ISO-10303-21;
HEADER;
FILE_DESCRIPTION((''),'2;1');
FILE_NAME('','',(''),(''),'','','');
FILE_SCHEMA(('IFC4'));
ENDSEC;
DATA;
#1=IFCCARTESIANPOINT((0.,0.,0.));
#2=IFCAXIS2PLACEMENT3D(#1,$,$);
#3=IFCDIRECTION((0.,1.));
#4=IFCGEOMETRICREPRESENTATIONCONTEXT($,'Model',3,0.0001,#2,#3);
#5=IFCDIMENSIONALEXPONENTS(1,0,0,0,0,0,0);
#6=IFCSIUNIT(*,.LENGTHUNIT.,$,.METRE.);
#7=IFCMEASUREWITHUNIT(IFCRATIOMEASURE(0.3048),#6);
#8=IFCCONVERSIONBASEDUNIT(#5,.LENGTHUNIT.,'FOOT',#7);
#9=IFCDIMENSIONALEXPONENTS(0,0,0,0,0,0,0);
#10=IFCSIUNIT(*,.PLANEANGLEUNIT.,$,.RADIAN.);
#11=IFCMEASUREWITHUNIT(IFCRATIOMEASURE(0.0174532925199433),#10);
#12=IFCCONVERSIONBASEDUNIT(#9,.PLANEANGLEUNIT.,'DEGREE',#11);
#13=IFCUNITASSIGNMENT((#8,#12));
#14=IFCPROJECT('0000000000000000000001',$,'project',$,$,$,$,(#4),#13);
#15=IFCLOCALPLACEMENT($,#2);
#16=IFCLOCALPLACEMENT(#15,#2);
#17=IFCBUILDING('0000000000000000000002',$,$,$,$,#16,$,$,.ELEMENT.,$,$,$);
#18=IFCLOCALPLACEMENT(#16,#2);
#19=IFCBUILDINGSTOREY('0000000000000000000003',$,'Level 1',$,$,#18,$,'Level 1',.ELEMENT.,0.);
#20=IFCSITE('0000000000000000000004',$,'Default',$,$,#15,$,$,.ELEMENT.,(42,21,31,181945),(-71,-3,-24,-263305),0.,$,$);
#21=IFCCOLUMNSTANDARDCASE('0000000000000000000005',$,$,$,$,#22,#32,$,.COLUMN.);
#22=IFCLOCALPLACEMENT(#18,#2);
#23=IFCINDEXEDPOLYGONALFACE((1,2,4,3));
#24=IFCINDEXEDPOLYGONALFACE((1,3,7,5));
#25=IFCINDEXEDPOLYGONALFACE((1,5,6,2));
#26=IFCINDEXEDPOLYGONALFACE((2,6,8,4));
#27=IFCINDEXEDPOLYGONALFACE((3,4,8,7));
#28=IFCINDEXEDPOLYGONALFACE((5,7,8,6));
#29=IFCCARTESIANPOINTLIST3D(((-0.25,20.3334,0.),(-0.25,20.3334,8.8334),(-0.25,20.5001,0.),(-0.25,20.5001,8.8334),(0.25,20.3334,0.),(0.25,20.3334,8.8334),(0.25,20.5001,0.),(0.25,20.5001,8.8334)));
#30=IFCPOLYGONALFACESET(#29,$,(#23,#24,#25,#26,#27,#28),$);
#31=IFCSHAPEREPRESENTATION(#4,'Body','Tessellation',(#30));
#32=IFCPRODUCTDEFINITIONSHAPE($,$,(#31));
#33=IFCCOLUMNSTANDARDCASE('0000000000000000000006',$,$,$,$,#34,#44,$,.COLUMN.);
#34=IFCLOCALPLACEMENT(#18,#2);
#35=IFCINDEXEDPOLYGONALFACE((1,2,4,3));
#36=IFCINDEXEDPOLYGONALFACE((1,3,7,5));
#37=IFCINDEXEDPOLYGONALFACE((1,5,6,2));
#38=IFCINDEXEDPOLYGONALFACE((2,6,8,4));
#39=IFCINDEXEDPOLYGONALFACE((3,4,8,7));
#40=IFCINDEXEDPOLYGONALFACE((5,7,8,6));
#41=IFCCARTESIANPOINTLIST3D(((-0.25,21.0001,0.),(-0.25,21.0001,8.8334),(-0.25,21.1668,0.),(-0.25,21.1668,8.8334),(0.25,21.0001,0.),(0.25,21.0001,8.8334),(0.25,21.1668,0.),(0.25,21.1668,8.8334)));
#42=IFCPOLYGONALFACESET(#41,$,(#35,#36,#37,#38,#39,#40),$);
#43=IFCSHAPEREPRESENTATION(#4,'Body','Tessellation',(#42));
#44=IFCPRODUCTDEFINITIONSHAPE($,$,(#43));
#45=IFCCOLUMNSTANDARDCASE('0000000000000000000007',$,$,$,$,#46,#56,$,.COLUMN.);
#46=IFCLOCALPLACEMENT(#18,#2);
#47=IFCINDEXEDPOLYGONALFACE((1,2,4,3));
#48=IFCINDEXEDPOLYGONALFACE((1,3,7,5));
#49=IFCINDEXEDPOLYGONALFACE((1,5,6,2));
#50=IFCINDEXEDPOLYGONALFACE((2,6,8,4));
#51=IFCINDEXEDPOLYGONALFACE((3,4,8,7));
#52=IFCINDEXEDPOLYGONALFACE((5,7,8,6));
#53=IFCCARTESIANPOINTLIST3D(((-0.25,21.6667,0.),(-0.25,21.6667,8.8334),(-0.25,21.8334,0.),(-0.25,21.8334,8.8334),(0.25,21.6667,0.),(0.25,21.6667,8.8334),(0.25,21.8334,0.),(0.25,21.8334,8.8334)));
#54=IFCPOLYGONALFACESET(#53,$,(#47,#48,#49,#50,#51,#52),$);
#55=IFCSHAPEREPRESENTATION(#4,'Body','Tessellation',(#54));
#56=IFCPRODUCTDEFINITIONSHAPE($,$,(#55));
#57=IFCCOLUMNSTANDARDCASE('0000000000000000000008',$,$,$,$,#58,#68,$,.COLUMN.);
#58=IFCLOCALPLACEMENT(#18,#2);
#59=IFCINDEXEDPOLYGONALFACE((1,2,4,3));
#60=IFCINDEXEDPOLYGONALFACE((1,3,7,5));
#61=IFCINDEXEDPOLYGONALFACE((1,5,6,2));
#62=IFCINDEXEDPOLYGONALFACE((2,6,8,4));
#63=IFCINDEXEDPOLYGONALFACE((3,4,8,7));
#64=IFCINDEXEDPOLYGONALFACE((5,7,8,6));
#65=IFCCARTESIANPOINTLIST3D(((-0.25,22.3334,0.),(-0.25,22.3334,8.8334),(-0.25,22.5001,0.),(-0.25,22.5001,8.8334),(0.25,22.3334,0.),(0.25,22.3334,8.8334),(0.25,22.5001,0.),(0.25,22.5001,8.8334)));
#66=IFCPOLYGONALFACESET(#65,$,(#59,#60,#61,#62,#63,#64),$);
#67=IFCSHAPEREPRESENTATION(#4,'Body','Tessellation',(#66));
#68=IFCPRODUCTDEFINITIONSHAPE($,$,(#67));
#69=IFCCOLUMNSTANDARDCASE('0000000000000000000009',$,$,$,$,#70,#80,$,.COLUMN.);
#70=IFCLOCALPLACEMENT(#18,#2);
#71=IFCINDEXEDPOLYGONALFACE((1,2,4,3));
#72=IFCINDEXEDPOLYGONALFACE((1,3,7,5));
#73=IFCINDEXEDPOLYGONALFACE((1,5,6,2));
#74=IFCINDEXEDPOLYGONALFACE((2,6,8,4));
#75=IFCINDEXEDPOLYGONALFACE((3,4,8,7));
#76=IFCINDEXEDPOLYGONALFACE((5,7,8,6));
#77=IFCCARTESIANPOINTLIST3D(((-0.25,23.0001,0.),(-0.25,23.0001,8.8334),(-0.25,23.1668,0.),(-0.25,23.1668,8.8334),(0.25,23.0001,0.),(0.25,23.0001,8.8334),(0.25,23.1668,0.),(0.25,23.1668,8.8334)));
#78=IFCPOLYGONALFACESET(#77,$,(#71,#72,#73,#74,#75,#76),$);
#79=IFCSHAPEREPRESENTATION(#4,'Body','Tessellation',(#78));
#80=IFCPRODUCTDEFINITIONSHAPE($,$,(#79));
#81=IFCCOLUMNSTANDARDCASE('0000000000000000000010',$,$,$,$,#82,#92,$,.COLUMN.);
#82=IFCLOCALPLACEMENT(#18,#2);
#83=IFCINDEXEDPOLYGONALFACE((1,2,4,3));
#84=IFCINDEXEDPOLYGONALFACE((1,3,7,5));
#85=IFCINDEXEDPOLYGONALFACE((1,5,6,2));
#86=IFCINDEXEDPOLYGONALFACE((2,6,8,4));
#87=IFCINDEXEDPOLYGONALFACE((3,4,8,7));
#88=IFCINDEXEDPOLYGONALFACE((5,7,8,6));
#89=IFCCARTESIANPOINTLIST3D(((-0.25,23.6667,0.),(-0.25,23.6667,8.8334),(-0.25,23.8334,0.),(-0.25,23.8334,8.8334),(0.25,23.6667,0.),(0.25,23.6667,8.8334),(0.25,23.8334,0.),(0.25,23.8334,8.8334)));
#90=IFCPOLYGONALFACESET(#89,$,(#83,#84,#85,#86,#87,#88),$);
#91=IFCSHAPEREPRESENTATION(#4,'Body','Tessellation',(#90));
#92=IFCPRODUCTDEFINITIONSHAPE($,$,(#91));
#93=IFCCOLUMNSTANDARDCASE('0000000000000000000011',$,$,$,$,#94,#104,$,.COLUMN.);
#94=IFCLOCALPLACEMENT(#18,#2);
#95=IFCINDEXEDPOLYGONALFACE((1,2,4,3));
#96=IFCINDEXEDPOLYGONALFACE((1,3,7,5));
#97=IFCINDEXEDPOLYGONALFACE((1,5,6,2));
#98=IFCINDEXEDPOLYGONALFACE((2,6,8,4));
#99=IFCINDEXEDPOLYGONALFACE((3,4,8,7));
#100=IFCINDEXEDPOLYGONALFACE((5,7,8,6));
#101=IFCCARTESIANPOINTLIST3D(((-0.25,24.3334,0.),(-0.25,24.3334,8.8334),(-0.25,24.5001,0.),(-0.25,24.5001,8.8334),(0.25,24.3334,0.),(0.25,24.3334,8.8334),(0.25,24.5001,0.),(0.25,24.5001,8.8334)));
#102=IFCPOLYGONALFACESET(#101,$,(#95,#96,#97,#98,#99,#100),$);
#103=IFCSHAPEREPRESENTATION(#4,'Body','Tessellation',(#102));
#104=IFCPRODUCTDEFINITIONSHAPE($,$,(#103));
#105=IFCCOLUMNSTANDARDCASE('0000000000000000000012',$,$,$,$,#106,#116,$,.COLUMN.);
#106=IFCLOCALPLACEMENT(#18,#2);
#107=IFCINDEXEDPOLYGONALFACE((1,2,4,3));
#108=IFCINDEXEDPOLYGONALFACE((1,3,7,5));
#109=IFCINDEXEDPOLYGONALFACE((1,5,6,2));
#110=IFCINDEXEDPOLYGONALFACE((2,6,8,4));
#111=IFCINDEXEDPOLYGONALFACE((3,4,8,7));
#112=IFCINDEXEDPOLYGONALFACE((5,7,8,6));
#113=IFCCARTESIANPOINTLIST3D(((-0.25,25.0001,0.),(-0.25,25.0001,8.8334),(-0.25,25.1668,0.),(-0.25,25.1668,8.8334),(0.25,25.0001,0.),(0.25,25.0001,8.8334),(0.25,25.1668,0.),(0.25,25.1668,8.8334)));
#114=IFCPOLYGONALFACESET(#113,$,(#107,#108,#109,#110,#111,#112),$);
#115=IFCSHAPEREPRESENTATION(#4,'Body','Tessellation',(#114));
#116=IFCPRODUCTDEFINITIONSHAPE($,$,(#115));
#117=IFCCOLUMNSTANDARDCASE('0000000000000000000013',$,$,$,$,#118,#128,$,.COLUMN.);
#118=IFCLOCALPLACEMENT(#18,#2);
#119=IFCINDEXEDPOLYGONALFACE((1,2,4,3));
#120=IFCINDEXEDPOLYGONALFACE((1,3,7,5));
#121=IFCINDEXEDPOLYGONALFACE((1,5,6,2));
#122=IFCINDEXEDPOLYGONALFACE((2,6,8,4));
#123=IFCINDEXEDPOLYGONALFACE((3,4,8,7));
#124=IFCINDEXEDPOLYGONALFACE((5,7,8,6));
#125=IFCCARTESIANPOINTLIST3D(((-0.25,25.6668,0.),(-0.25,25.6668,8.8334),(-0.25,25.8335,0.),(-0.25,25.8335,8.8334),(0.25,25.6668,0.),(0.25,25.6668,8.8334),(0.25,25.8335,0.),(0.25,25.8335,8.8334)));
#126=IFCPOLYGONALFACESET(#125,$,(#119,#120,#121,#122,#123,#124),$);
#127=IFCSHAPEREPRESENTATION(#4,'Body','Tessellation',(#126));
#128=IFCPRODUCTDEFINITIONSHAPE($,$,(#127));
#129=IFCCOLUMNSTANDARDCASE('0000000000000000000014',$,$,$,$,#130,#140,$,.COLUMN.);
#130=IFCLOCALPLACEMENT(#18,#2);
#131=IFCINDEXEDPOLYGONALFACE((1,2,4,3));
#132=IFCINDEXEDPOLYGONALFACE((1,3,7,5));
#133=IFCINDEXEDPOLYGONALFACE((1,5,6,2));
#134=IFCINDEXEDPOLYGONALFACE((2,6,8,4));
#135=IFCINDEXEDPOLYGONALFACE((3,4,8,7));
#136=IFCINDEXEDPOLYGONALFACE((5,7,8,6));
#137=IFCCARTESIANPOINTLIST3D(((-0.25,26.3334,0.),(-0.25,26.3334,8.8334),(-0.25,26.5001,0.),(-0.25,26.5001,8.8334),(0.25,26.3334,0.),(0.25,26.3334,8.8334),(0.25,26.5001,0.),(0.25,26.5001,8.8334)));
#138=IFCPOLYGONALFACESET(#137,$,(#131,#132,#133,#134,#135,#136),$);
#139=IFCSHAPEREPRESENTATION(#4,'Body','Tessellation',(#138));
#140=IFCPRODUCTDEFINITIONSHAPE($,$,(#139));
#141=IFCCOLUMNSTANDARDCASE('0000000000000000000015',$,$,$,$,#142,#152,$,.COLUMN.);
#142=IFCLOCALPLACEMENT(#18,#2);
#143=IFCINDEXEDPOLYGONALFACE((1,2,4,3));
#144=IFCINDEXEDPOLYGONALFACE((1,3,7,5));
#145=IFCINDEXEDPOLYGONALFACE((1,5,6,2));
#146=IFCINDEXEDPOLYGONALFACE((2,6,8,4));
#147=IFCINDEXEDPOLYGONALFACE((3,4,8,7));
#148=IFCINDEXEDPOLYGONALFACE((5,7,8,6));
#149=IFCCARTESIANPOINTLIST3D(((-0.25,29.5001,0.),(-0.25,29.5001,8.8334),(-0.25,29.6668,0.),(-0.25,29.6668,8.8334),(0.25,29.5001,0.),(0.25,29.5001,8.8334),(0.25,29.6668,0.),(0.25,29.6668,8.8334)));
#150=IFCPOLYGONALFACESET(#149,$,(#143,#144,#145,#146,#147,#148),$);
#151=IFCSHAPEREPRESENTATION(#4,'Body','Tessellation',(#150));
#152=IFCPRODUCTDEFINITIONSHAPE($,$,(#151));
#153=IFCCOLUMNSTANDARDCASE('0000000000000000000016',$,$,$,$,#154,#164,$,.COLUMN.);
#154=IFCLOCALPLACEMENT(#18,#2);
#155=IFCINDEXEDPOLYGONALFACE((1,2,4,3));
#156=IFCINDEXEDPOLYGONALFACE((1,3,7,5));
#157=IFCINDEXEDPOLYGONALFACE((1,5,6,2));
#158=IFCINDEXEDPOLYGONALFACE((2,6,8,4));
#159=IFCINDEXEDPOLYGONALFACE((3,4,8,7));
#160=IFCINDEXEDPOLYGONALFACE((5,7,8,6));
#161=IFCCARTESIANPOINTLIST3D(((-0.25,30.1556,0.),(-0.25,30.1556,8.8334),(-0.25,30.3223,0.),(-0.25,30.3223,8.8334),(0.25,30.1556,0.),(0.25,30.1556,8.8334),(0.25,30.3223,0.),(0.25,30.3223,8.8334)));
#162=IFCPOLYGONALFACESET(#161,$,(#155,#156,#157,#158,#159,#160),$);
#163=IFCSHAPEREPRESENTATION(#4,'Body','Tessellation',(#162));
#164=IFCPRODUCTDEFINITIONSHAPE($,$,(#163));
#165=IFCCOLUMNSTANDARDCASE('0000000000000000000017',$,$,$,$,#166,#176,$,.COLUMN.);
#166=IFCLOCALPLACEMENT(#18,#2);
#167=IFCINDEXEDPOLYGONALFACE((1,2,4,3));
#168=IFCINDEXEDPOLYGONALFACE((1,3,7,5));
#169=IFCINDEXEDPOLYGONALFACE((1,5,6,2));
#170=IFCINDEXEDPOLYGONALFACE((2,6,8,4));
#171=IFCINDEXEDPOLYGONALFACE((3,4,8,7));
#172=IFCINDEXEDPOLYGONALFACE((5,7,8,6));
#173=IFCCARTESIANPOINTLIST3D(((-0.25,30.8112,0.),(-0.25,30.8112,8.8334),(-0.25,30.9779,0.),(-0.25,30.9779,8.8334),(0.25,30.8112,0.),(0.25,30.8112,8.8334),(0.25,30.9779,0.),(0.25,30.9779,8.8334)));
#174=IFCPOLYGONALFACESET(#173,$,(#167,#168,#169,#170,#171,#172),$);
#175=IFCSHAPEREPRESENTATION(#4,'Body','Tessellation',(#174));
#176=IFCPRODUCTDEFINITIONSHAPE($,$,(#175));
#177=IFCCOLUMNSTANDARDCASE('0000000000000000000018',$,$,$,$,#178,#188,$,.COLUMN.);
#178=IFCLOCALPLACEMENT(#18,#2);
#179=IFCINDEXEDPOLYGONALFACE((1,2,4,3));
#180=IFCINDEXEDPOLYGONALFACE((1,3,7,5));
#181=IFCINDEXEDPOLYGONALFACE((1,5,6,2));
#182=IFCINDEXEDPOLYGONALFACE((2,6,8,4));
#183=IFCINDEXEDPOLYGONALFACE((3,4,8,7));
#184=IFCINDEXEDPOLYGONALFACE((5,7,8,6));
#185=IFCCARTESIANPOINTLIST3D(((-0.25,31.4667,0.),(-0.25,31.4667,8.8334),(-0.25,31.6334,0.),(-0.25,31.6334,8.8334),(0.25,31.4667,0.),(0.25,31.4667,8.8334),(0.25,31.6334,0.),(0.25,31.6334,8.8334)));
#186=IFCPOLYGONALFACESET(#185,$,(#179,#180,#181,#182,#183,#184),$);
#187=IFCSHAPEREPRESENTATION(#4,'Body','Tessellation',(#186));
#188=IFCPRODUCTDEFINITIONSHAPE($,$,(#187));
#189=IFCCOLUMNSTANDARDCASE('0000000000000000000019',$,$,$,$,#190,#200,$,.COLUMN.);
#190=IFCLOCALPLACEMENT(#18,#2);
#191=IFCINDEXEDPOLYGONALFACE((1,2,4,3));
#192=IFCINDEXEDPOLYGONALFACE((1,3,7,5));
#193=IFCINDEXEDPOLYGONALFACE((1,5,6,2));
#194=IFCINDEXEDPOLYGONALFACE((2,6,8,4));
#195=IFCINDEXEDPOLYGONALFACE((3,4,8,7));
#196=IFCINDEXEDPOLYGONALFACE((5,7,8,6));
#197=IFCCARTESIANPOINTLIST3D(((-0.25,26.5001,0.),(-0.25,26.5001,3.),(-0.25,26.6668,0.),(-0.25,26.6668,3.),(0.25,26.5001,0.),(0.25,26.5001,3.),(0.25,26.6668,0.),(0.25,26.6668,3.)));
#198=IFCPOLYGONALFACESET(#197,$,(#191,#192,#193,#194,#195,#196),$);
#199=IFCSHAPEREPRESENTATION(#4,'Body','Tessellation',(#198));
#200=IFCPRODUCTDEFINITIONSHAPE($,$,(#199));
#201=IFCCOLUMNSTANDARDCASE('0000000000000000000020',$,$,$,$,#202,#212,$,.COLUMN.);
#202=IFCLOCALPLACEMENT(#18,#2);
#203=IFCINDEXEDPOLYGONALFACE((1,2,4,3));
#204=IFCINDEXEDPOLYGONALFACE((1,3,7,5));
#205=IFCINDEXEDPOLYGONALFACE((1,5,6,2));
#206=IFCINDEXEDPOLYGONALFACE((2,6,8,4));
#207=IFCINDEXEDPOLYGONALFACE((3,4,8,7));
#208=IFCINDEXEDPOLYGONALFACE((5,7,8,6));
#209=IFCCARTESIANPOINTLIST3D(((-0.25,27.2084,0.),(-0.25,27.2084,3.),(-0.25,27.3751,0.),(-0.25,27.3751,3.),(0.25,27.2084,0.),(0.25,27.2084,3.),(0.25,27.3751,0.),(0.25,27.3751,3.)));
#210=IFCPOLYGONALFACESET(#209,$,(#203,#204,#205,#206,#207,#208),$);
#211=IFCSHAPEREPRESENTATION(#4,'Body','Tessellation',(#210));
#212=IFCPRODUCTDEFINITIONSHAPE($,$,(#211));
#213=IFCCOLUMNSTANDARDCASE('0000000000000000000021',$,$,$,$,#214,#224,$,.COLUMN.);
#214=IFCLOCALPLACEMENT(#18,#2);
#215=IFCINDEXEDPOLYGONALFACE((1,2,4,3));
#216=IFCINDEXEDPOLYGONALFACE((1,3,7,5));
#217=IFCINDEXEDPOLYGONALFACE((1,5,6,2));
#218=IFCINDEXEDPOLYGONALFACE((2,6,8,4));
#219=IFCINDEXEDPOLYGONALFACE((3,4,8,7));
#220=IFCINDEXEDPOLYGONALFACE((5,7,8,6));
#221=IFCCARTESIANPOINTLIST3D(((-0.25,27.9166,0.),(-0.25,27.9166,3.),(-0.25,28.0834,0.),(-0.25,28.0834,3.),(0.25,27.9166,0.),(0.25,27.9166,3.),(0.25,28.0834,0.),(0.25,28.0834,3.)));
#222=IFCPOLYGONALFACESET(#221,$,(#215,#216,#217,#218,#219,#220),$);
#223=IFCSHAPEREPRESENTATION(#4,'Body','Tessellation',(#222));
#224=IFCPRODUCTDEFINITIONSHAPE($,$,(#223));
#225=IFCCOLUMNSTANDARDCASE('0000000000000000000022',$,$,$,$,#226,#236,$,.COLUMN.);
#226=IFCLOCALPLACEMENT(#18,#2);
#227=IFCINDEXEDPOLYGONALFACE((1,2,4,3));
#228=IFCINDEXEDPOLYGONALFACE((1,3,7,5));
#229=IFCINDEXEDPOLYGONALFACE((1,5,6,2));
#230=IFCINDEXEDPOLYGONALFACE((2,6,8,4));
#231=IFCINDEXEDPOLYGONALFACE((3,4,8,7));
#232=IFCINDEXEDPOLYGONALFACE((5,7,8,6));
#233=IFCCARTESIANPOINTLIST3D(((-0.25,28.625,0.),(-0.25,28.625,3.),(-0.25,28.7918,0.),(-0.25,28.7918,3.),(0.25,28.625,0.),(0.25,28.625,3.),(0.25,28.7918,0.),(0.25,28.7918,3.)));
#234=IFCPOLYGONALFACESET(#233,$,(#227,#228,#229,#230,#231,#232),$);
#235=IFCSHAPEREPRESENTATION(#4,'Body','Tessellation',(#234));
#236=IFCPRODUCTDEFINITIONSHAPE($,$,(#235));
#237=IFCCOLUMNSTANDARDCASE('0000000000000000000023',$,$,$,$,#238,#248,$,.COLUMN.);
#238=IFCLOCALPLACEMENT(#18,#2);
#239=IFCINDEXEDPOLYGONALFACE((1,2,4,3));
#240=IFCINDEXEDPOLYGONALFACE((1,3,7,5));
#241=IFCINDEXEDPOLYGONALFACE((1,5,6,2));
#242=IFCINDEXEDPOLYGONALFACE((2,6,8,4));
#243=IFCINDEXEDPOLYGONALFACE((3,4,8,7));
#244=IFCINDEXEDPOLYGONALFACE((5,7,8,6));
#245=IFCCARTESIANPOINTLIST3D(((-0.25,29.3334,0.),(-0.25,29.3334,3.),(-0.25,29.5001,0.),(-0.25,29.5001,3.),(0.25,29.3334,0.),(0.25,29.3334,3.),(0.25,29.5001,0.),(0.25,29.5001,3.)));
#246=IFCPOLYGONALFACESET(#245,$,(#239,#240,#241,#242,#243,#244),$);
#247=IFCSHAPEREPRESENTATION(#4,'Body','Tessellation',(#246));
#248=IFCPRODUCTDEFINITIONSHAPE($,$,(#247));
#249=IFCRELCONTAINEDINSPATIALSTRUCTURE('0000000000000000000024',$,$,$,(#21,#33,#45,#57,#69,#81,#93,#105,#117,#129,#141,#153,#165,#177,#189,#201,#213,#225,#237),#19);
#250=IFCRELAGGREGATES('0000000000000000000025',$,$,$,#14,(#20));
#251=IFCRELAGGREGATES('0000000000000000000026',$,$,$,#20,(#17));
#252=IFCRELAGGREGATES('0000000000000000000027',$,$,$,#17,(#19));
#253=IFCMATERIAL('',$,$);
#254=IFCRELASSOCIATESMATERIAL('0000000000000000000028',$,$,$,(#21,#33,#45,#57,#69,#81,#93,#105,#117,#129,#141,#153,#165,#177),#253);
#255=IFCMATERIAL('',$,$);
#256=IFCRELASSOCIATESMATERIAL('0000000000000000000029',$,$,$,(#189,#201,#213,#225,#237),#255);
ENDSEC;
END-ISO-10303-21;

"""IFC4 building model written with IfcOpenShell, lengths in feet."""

from ifc_helpers import new_model, entity, si_unit, converted_unit, direction, frame, origin, place, context, project, spatial, rectangle, extrude, material, element, save


model = new_model("IFC4")

# Units and contexts
model_context = context("Model", 3, precision=0.0001, world=origin(), true_north=direction((0.0, 1.0)))
ifc_project = project(units=[converted_unit("LENGTHUNIT", "FOOT", entity("IfcRatioMeasure", 0.3048), si_unit("LENGTHUNIT", "METRE"), dimensions=[1, 0, 0, 0, 0, 0, 0]), converted_unit("PLANEANGLEUNIT", "DEGREE", entity("IfcRatioMeasure", 0.0174532925199433), si_unit("PLANEANGLEUNIT", "RADIAN"), dimensions=[0, 0, 0, 0, 0, 0, 0])], contexts=[model_context])

# Site, building, storey
site_placement = place(None, origin())
site = spatial("IfcSite", under=ifc_project, at=site_placement, Name="Default", CompositionType="ELEMENT", RefLatitude=(42, 21, 31, 181945), RefLongitude=(-71, -3, -24, -263305), RefElevation=0.0)
building_placement = place(site_placement, origin())
building = spatial("IfcBuilding", under=site, at=building_placement, CompositionType="ELEMENT")
storey_placement = place(building_placement, origin())
storey = spatial("IfcBuildingStorey", under=building, at=storey_placement, Name="Level 1", LongName="Level 1", CompositionType="ELEMENT", Elevation=0.0)

# Columns
ifc_material_1 = material(Name="")
placement_1 = place(storey_placement, frame((0.0, -0.25, 0.0), z_axis=(0.0, 0.0, 1.0), x_axis=(0.0, 1.0, 0.0)))
for number, where, z_axis, x_axis in (
    (1, (20.6667, 0.0, 0.0), (0.0, 0.0, 1.0), (1.0, 0.0, 0.0)),
    (2, (21.3334, 0.0, 0.0), (0.0, 0.0, 1.0), (1.0, 0.0, 0.0)),
    (3, (22.0, 0.0, 0.0), (0.0, 0.0, 1.0), (1.0, 0.0, 0.0)),
    (4, (22.6667, 0.0, 0.0), (0.0, 0.0, 1.0), (1.0, 0.0, 0.0)),
    (5, (23.3334, 0.0, 0.0), (0.0, 0.0, 1.0), (1.0, 0.0, 0.0)),
    (6, (24.0, 0.0, 0.0), (0.0, 0.0, 1.0), (1.0, 0.0, 0.0)),
    (7, (24.6667, 0.0, 0.0), (0.0, 0.0, 1.0), (1.0, 0.0, 0.0)),
    (8, (25.3334, 0.0, 0.0), (0.0, 0.0, 1.0), (1.0, 0.0, 0.0)),
    (9, (26.0001, 0.0, 0.0), (0.0, 0.0, 1.0), (1.0, 0.0, 0.0)),
    (10, (26.6667, 0.0, 0.0), (0.0, 0.0, 1.0), (1.0, 0.0, 0.0)),
    (11, (29.8334, 0.0, 0.0), (0.0, 0.0, 1.0), (1.0, 0.0, 0.0)),
    (12, (30.4889, 0.0, 0.0), (0.0, 0.0, 1.0), (1.0, 0.0, 0.0)),
    (13, (31.1445, 0.0, 0.0), (0.0, 0.0, 1.0), (1.0, 0.0, 0.0)),
    (14, (31.8, 0.0, 0.0), (0.0, 0.0, 1.0), (1.0, 0.0, 0.0)),
):
    element("IfcColumnStandardCase", number, at=place(placement_1, frame(where, z_axis=z_axis, x_axis=x_axis)), inside=storey, material=ifc_material_1, PredefinedType="COLUMN", context=model_context, shape_type="SweptSolid", body=[
        extrude(rectangle(XDim=0.1667, YDim=0.5), origin(), (0.0, 0.0, 1.0), 8.8334),
    ])
ifc_material_2 = material(Name="")
for number, where, z_axis, x_axis in (
    (15, (26.8334, 0.0, 0.0), (0.0, 0.0, 1.0), (1.0, 0.0, 0.0)),
    (16, (27.5417, 0.0, 0.0), (0.0, 0.0, 1.0), (1.0, 0.0, 0.0)),
    (17, (28.25, 0.0, 0.0), (0.0, 0.0, 1.0), (1.0, 0.0, 0.0)),
    (18, (28.9584, 0.0, 0.0), (0.0, 0.0, 1.0), (1.0, 0.0, 0.0)),
    (19, (29.6667, 0.0, 0.0), (0.0, 0.0, 1.0), (1.0, 0.0, 0.0)),
):
    element("IfcColumnStandardCase", number, at=place(placement_1, frame(where, z_axis=z_axis, x_axis=x_axis)), inside=storey, material=ifc_material_2, PredefinedType="COLUMN", context=model_context, shape_type="SweptSolid", body=[
        extrude(rectangle(XDim=0.1667, YDim=0.5), origin(), (0.0, 0.0, 1.0), 3.0),
    ])

save(model, "model.ifc")
